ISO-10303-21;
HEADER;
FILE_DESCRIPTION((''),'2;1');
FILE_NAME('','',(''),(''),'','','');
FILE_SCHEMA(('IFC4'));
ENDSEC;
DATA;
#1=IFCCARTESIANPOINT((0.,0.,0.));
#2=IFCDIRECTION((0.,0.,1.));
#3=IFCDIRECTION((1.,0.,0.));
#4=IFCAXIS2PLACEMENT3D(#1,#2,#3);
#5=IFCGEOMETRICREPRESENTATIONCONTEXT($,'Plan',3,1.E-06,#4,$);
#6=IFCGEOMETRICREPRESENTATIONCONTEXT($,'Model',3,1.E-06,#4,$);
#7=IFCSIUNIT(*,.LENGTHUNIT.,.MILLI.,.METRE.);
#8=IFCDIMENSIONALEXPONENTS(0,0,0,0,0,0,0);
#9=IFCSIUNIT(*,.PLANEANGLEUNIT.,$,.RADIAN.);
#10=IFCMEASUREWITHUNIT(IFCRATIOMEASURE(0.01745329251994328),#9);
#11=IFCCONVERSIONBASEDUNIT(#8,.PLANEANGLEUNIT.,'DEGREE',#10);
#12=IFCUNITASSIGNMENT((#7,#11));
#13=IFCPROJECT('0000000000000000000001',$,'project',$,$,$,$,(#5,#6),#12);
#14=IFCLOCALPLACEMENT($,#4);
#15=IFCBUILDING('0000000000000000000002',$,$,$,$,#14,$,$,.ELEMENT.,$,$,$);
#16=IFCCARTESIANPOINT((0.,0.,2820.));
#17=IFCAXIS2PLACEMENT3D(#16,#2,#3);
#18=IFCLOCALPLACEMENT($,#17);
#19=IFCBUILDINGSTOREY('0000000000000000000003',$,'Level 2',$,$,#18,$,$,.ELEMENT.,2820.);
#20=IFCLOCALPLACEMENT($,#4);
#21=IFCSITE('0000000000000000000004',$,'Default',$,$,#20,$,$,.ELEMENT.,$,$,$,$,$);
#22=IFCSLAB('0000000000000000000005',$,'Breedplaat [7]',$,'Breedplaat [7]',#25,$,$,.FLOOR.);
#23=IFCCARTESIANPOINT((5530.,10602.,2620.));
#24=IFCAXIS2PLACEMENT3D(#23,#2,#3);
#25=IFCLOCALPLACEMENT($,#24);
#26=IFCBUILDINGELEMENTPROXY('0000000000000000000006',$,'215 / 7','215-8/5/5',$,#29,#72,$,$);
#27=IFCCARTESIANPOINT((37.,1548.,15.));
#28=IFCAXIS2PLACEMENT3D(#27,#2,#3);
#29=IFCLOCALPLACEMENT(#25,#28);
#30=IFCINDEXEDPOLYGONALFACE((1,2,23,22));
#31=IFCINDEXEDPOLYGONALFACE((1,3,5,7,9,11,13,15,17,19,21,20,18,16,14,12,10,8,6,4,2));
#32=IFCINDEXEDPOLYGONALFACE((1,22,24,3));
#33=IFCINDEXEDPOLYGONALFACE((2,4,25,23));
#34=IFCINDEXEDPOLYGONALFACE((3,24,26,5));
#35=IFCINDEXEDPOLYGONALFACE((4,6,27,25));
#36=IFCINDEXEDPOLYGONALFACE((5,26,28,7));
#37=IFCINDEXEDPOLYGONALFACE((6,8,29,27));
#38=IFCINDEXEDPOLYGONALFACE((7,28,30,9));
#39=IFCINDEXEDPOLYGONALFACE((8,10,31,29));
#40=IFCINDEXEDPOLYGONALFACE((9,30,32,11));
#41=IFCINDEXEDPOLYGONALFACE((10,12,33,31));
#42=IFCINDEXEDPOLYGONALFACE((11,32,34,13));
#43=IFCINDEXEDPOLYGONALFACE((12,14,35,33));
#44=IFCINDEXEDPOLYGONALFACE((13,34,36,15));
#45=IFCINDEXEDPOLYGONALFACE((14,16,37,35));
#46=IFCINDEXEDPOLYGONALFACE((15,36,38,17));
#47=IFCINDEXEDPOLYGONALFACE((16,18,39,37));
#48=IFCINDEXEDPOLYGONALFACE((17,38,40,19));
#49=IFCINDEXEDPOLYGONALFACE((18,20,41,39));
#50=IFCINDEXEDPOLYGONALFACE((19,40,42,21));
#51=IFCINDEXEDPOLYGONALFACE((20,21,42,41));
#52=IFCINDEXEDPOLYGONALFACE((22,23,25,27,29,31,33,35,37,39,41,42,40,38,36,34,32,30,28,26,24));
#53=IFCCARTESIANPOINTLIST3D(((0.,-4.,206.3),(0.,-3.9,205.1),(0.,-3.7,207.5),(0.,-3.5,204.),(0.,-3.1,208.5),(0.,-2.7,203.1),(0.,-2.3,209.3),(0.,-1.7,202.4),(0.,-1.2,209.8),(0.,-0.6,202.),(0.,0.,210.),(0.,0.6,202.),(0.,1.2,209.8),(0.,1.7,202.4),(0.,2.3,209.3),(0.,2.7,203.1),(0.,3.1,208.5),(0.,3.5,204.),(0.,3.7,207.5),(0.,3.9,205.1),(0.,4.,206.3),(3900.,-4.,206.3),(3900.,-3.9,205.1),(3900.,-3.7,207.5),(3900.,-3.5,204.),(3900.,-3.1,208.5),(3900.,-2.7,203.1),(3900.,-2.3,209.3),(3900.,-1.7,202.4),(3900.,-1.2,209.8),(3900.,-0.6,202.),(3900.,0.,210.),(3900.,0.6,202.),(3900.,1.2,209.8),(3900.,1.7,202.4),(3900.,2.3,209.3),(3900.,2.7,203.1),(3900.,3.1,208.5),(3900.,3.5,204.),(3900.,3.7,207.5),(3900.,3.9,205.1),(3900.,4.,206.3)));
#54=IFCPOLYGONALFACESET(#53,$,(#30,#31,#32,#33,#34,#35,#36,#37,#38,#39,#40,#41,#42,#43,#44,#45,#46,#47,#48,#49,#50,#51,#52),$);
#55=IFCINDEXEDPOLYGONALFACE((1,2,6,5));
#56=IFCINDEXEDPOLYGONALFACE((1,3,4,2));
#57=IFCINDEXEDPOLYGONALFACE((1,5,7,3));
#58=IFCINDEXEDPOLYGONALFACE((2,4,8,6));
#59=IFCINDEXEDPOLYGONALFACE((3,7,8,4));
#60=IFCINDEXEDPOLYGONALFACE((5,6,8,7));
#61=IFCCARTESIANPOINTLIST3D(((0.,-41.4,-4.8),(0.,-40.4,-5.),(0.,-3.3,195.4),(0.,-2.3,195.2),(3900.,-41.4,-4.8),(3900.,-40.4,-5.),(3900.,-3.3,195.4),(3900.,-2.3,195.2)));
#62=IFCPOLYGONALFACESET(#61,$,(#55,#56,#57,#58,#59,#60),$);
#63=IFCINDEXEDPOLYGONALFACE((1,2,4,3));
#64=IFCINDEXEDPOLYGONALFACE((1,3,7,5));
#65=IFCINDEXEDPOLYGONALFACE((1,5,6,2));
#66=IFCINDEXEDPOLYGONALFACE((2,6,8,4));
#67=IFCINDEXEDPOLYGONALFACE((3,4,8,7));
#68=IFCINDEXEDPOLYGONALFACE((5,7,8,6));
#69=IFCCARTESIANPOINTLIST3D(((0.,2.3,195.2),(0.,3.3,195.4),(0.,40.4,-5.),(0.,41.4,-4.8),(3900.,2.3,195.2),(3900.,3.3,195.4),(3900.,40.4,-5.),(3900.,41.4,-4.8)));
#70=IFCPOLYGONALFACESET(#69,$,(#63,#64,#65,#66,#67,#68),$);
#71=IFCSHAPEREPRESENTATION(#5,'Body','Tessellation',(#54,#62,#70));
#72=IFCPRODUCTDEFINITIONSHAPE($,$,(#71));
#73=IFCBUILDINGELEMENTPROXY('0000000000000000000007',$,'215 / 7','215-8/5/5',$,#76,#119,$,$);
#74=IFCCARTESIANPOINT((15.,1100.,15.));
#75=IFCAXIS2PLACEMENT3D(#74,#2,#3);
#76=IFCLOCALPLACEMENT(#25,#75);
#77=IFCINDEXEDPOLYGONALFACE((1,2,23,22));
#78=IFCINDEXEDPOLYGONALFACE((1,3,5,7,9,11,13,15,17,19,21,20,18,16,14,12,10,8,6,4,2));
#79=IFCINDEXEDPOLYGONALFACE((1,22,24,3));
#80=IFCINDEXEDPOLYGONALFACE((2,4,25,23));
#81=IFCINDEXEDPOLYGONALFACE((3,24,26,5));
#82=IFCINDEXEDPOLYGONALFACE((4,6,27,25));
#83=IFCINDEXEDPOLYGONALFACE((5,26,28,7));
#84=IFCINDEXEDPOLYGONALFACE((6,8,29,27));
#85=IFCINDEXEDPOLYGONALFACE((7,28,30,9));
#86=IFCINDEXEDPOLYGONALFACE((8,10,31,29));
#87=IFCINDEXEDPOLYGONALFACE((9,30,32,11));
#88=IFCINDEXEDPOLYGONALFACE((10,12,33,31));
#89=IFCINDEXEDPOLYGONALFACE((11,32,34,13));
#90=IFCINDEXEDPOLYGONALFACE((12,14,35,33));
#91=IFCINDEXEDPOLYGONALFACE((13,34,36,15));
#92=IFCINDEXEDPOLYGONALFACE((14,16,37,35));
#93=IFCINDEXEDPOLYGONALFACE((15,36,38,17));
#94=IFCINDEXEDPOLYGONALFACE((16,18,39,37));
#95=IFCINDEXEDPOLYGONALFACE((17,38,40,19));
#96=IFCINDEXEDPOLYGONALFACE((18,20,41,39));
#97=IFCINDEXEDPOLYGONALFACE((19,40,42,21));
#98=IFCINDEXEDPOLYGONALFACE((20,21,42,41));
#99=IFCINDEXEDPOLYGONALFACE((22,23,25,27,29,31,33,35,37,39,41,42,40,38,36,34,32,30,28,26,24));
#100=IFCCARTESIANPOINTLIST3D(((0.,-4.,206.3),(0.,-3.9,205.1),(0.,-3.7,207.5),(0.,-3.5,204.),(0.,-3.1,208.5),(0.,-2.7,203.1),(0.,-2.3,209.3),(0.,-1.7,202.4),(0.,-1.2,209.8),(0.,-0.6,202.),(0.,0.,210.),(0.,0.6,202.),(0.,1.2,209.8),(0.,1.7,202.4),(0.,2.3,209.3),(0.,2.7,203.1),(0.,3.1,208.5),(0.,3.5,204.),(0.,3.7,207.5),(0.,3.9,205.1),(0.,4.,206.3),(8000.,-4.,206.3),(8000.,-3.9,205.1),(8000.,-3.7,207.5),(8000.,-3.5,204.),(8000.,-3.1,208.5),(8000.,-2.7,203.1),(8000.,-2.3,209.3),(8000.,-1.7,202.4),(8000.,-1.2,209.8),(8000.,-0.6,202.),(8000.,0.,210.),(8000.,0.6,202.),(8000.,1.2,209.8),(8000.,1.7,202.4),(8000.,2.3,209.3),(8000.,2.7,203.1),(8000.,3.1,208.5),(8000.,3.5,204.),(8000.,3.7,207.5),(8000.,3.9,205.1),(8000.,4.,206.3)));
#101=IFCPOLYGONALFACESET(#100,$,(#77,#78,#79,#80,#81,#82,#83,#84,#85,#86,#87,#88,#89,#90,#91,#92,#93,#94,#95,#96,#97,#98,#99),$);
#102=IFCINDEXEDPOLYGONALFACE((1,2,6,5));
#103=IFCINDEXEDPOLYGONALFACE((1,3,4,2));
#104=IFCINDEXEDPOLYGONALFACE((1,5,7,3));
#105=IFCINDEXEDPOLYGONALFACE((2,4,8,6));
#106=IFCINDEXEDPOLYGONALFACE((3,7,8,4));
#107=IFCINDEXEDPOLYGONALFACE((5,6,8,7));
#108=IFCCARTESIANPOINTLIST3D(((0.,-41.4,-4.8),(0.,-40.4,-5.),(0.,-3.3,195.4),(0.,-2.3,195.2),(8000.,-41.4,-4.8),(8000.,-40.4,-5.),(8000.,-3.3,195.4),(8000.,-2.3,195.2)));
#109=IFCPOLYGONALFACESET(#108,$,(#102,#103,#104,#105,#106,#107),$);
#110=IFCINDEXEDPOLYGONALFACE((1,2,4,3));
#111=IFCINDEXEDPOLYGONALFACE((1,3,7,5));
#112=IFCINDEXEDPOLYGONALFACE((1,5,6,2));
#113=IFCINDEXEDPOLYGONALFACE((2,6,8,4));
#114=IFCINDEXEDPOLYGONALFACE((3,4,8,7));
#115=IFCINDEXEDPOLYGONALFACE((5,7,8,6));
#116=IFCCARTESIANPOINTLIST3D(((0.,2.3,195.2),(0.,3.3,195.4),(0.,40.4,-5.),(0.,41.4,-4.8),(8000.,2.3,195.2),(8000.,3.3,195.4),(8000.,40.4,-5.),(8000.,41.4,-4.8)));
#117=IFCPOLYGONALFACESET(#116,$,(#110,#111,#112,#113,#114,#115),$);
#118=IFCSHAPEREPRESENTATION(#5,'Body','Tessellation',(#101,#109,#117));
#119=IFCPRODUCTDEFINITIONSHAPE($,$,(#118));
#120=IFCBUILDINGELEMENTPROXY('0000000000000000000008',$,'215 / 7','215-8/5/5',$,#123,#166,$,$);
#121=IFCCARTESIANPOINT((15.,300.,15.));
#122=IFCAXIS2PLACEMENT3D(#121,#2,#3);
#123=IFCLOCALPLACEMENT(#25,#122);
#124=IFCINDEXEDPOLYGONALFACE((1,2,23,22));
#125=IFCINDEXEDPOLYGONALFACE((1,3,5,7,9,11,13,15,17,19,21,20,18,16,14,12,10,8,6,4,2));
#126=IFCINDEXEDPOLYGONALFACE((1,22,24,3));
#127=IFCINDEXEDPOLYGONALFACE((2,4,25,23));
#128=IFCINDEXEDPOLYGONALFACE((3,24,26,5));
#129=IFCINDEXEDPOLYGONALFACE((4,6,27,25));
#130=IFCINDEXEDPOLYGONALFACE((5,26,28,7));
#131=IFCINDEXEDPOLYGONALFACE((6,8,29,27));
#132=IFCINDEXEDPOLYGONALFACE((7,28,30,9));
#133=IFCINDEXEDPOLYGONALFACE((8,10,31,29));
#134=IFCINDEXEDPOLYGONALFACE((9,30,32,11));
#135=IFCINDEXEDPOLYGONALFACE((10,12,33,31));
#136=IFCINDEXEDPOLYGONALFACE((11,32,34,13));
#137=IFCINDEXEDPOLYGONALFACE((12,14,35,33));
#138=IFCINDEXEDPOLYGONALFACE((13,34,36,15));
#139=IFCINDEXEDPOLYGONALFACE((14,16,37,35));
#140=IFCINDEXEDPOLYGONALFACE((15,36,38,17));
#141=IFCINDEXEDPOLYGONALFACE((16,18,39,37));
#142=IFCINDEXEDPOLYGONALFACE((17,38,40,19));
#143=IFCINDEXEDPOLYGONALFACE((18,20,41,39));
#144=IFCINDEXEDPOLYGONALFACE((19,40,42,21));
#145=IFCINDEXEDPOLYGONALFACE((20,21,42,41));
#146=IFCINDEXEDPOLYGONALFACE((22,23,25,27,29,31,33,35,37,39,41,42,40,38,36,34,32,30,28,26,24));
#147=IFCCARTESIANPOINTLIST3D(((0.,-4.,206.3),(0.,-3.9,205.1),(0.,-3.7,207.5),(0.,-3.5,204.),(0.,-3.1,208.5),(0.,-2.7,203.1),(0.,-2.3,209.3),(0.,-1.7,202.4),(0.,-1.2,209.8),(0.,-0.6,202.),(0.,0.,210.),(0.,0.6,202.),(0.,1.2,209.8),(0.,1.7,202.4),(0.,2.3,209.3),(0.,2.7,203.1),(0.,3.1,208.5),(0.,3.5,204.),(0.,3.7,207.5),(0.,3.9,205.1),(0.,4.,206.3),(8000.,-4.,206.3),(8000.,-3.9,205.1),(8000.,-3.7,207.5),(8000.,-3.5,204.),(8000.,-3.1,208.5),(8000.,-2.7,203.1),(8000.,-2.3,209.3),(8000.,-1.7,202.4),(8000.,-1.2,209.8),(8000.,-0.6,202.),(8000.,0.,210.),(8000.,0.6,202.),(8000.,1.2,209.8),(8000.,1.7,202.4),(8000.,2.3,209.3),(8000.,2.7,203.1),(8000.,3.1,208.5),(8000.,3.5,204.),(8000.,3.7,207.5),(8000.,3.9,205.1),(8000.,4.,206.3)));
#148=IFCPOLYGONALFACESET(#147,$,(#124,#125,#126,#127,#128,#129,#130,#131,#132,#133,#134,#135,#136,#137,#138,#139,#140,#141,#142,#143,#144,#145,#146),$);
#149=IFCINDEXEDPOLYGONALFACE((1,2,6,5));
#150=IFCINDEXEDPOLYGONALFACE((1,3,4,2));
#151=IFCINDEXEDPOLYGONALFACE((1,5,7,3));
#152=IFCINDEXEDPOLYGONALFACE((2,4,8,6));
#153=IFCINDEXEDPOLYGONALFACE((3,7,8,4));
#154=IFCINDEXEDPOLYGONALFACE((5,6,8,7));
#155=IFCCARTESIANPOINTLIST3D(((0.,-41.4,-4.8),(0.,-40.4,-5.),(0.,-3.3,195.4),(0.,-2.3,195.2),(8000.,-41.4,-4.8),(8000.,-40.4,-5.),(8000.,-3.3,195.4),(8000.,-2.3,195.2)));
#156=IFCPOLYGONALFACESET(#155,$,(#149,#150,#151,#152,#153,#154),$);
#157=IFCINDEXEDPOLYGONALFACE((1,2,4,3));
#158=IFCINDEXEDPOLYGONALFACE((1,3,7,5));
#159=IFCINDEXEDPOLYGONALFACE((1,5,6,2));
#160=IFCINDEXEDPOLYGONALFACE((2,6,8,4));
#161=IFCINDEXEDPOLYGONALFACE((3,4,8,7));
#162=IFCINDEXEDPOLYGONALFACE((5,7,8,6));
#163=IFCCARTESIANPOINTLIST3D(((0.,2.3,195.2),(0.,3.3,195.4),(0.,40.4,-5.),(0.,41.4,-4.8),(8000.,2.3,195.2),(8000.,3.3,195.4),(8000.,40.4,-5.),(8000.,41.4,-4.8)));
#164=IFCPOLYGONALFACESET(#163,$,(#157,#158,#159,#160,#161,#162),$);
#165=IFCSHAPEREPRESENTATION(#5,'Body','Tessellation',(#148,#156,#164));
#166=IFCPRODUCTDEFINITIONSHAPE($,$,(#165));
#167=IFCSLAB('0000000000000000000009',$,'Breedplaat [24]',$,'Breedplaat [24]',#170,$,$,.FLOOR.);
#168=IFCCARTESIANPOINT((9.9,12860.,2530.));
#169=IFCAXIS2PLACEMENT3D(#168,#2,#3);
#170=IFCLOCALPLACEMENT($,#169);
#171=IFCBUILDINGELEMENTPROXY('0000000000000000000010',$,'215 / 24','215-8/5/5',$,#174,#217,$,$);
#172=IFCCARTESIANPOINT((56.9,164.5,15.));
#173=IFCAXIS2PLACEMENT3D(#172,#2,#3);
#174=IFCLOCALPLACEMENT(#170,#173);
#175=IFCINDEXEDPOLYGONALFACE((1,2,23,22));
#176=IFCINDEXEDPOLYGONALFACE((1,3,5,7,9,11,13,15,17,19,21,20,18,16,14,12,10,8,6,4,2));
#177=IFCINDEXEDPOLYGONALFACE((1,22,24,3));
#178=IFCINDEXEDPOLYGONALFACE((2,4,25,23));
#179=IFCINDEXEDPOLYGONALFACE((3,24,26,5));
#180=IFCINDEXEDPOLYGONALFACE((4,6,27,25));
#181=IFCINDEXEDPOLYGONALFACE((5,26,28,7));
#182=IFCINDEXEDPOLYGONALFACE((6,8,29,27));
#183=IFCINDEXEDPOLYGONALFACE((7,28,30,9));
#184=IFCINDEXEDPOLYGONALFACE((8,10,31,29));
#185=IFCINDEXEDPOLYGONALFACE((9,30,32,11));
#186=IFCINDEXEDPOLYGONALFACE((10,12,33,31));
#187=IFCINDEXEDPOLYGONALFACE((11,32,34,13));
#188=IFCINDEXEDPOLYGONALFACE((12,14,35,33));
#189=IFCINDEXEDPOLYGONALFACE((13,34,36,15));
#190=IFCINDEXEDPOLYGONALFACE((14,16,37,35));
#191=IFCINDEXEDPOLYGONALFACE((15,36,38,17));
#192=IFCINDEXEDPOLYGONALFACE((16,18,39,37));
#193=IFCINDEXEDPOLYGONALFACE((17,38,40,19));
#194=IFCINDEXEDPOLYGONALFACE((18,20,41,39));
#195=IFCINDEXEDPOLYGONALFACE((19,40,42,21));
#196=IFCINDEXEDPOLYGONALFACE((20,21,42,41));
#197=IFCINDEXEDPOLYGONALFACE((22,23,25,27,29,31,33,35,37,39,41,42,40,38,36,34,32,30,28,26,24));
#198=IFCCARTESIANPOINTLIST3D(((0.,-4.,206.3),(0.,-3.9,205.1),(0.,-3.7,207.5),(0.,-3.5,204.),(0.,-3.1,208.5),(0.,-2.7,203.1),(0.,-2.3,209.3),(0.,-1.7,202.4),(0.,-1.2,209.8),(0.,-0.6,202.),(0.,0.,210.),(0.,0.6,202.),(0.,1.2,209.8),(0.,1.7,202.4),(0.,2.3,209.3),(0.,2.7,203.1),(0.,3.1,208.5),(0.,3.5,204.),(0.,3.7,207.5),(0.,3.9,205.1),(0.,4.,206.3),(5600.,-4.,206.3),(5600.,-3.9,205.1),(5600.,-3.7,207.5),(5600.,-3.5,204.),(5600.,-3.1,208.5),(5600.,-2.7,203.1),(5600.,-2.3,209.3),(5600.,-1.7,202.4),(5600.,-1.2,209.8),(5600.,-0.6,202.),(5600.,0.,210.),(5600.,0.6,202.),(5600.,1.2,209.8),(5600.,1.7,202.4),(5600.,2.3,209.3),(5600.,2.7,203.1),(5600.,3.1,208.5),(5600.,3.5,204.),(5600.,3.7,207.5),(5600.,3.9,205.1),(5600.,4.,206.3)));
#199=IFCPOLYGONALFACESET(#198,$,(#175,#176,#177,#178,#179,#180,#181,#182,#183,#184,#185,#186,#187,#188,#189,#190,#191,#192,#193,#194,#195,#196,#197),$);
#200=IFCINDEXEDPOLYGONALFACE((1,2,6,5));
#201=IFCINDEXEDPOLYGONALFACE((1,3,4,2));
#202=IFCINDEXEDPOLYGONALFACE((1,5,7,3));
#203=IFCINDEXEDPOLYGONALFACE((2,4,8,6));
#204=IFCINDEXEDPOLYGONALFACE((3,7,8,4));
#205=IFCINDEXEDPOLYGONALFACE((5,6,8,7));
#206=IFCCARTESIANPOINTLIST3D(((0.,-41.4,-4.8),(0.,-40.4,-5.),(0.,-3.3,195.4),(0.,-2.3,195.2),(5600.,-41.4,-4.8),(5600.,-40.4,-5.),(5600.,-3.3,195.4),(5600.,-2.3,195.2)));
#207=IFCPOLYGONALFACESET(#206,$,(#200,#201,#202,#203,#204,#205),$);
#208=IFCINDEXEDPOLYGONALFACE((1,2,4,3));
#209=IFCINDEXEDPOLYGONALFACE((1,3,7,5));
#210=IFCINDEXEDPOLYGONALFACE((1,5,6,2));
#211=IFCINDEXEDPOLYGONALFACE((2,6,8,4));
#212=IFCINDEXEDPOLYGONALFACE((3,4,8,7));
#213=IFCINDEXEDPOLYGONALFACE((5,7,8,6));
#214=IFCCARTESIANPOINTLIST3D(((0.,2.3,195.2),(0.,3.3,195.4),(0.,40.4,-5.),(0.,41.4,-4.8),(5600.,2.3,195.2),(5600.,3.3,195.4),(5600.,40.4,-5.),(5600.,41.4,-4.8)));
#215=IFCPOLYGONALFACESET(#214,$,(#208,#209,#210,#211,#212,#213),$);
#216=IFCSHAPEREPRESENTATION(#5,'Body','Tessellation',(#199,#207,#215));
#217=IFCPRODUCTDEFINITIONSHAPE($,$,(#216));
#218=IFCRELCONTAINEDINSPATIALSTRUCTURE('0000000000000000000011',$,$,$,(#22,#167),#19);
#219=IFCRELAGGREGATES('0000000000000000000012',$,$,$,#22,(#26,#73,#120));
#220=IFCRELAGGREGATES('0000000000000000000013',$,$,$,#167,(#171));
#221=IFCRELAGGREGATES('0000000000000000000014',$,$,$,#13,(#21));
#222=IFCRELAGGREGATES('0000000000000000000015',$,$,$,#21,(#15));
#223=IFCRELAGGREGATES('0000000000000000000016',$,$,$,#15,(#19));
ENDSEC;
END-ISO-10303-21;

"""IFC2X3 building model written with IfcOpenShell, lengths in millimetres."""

from ifc_helpers import new_model, entity, si_unit, converted_unit, frame, origin_with_axes, origin_2d_with_axis, place, context, project, spatial, rectangle, circle, extrude, element, aggregate, save


model = new_model("IFC2X3")

# Units and contexts
plan_context = context("Plan", 3, precision=1e-06, world=origin_with_axes())
model_context = context("Model", 3, precision=1e-06, world=origin_with_axes())
ifc_project = project(units=[si_unit("LENGTHUNIT", "METRE", prefix="MILLI"), converted_unit("PLANEANGLEUNIT", "DEGREE", entity("IfcRatioMeasure", 0.01745329251994328), si_unit("PLANEANGLEUNIT", "RADIAN"), dimensions=[0, 0, 0, 0, 0, 0, 0])], contexts=[plan_context, model_context])

# Site, building, storey
site_placement = place(None, origin_with_axes())
site = spatial("IfcSite", under=ifc_project, at=site_placement, Name="Default", CompositionType="ELEMENT")
building_placement = place(None, origin_with_axes())
building = spatial("IfcBuilding", under=site, at=building_placement, CompositionType="ELEMENT")
storey_placement = place(None, frame((0.0, 0.0, 2820.0), z_axis=(0.0, 0.0, 1.0), x_axis=(1.0, 0.0, 0.0)))
storey = spatial("IfcBuildingStorey", under=building, at=storey_placement, Name="Level 2", CompositionType="ELEMENT", Elevation=2820.0)

# Slab, building element proxies
slab_1_placement = place(None, frame((5530.0, 10602.0, 2620.0), z_axis=(0.0, 0.0, 1.0), x_axis=(1.0, 0.0, 0.0)))
slab_1 = element("IfcSlab", 1, at=slab_1_placement, inside=storey, Name="Breedplaat [7]", ObjectType="Breedplaat [7]", PredefinedType="FLOOR")
proxy_1_placement = place(slab_1_placement, frame((37.0, 1548.0, 15.0), z_axis=(0.0, 0.0, 1.0), x_axis=(1.0, 0.0, 0.0)))
proxy_1 = element("IfcBuildingElementProxy", 2, at=proxy_1_placement, Name="215 / 7", Description="215-8/5/5", context=plan_context, shape_type="SweptSolid", body=[
    extrude(circle(Radius=4.0, at=origin_2d_with_axis()), frame((0.0, 0.0, 206.0), z_axis=(1.0, 0.0, 0.0), x_axis=(0.0, 0.0, 1.0)), (0.0, 0.0, 1.0), 3900.0),
    extrude(rectangle(XDim=203.8, YDim=1.0, at=origin_2d_with_axis()), frame((0.0, -21.9, 95.2), z_axis=(1.0, 0.0, 0.0), x_axis=(0.0, 0.187112, 0.982339)), (0.0, 0.0, 1.0), 3900.0),
    extrude(rectangle(XDim=203.8, YDim=1.0, at=origin_2d_with_axis()), frame((0.0, 21.9, 95.2), z_axis=(1.0, 0.0, 0.0), x_axis=(0.0, -0.187112, 0.982339)), (0.0, 0.0, 1.0), 3900.0),
])
proxy_2_placement = place(slab_1_placement, frame((15.0, 1100.0, 15.0), z_axis=(0.0, 0.0, 1.0), x_axis=(1.0, 0.0, 0.0)))
proxy_2 = element("IfcBuildingElementProxy", 3, at=proxy_2_placement, Name="215 / 7", Description="215-8/5/5", context=plan_context, shape_type="SweptSolid", body=[
    extrude(circle(Radius=4.0, at=origin_2d_with_axis()), frame((0.0, 0.0, 206.0), z_axis=(1.0, 0.0, 0.0), x_axis=(0.0, 0.0, 1.0)), (0.0, 0.0, 1.0), 8000.0),
    extrude(rectangle(XDim=203.8, YDim=1.0, at=origin_2d_with_axis()), frame((0.0, -21.9, 95.2), z_axis=(1.0, 0.0, 0.0), x_axis=(0.0, 0.187112, 0.982339)), (0.0, 0.0, 1.0), 8000.0),
    extrude(rectangle(XDim=203.8, YDim=1.0, at=origin_2d_with_axis()), frame((0.0, 21.9, 95.2), z_axis=(1.0, 0.0, 0.0), x_axis=(0.0, -0.187112, 0.982339)), (0.0, 0.0, 1.0), 8000.0),
])
proxy_3_placement = place(slab_1_placement, frame((15.0, 300.0, 15.0), z_axis=(0.0, 0.0, 1.0), x_axis=(1.0, 0.0, 0.0)))
proxy_3 = element("IfcBuildingElementProxy", 4, at=proxy_3_placement, Name="215 / 7", Description="215-8/5/5", context=plan_context, shape_type="SweptSolid", body=[
    extrude(circle(Radius=4.0, at=origin_2d_with_axis()), frame((0.0, 0.0, 206.0), z_axis=(1.0, 0.0, 0.0), x_axis=(0.0, 0.0, 1.0)), (0.0, 0.0, 1.0), 8000.0),
    extrude(rectangle(XDim=203.8, YDim=1.0, at=origin_2d_with_axis()), frame((0.0, -21.9, 95.2), z_axis=(1.0, 0.0, 0.0), x_axis=(0.0, 0.187112, 0.982339)), (0.0, 0.0, 1.0), 8000.0),
    extrude(rectangle(XDim=203.8, YDim=1.0, at=origin_2d_with_axis()), frame((0.0, 21.9, 95.2), z_axis=(1.0, 0.0, 0.0), x_axis=(0.0, -0.187112, 0.982339)), (0.0, 0.0, 1.0), 8000.0),
])
aggregate(slab_1, [proxy_1, proxy_2, proxy_3])

# Slab, building element proxy
slab_2_placement = place(None, frame((9.9, 12860.0, 2530.0), z_axis=(0.0, 0.0, 1.0), x_axis=(1.0, 0.0, 0.0)))
slab_2 = element("IfcSlab", 5, at=slab_2_placement, inside=storey, Name="Breedplaat [24]", ObjectType="Breedplaat [24]", PredefinedType="FLOOR")
proxy_4_placement = place(slab_2_placement, frame((56.9, 164.5, 15.0), z_axis=(0.0, 0.0, 1.0), x_axis=(1.0, 0.0, 0.0)))
proxy_4 = element("IfcBuildingElementProxy", 6, at=proxy_4_placement, Name="215 / 24", Description="215-8/5/5", context=plan_context, shape_type="SweptSolid", body=[
    extrude(circle(Radius=4.0, at=origin_2d_with_axis()), frame((0.0, 0.0, 206.0), z_axis=(1.0, 0.0, 0.0), x_axis=(0.0, 0.0, 1.0)), (0.0, 0.0, 1.0), 5600.0),
    extrude(rectangle(XDim=203.8, YDim=1.0, at=origin_2d_with_axis()), frame((0.0, -21.9, 95.2), z_axis=(1.0, 0.0, 0.0), x_axis=(0.0, 0.187112, 0.982339)), (0.0, 0.0, 1.0), 5600.0),
    extrude(rectangle(XDim=203.8, YDim=1.0, at=origin_2d_with_axis()), frame((0.0, 21.9, 95.2), z_axis=(1.0, 0.0, 0.0), x_axis=(0.0, -0.187112, 0.982339)), (0.0, 0.0, 1.0), 5600.0),
])
aggregate(slab_2, [proxy_4])

save(model, "model.ifc")
